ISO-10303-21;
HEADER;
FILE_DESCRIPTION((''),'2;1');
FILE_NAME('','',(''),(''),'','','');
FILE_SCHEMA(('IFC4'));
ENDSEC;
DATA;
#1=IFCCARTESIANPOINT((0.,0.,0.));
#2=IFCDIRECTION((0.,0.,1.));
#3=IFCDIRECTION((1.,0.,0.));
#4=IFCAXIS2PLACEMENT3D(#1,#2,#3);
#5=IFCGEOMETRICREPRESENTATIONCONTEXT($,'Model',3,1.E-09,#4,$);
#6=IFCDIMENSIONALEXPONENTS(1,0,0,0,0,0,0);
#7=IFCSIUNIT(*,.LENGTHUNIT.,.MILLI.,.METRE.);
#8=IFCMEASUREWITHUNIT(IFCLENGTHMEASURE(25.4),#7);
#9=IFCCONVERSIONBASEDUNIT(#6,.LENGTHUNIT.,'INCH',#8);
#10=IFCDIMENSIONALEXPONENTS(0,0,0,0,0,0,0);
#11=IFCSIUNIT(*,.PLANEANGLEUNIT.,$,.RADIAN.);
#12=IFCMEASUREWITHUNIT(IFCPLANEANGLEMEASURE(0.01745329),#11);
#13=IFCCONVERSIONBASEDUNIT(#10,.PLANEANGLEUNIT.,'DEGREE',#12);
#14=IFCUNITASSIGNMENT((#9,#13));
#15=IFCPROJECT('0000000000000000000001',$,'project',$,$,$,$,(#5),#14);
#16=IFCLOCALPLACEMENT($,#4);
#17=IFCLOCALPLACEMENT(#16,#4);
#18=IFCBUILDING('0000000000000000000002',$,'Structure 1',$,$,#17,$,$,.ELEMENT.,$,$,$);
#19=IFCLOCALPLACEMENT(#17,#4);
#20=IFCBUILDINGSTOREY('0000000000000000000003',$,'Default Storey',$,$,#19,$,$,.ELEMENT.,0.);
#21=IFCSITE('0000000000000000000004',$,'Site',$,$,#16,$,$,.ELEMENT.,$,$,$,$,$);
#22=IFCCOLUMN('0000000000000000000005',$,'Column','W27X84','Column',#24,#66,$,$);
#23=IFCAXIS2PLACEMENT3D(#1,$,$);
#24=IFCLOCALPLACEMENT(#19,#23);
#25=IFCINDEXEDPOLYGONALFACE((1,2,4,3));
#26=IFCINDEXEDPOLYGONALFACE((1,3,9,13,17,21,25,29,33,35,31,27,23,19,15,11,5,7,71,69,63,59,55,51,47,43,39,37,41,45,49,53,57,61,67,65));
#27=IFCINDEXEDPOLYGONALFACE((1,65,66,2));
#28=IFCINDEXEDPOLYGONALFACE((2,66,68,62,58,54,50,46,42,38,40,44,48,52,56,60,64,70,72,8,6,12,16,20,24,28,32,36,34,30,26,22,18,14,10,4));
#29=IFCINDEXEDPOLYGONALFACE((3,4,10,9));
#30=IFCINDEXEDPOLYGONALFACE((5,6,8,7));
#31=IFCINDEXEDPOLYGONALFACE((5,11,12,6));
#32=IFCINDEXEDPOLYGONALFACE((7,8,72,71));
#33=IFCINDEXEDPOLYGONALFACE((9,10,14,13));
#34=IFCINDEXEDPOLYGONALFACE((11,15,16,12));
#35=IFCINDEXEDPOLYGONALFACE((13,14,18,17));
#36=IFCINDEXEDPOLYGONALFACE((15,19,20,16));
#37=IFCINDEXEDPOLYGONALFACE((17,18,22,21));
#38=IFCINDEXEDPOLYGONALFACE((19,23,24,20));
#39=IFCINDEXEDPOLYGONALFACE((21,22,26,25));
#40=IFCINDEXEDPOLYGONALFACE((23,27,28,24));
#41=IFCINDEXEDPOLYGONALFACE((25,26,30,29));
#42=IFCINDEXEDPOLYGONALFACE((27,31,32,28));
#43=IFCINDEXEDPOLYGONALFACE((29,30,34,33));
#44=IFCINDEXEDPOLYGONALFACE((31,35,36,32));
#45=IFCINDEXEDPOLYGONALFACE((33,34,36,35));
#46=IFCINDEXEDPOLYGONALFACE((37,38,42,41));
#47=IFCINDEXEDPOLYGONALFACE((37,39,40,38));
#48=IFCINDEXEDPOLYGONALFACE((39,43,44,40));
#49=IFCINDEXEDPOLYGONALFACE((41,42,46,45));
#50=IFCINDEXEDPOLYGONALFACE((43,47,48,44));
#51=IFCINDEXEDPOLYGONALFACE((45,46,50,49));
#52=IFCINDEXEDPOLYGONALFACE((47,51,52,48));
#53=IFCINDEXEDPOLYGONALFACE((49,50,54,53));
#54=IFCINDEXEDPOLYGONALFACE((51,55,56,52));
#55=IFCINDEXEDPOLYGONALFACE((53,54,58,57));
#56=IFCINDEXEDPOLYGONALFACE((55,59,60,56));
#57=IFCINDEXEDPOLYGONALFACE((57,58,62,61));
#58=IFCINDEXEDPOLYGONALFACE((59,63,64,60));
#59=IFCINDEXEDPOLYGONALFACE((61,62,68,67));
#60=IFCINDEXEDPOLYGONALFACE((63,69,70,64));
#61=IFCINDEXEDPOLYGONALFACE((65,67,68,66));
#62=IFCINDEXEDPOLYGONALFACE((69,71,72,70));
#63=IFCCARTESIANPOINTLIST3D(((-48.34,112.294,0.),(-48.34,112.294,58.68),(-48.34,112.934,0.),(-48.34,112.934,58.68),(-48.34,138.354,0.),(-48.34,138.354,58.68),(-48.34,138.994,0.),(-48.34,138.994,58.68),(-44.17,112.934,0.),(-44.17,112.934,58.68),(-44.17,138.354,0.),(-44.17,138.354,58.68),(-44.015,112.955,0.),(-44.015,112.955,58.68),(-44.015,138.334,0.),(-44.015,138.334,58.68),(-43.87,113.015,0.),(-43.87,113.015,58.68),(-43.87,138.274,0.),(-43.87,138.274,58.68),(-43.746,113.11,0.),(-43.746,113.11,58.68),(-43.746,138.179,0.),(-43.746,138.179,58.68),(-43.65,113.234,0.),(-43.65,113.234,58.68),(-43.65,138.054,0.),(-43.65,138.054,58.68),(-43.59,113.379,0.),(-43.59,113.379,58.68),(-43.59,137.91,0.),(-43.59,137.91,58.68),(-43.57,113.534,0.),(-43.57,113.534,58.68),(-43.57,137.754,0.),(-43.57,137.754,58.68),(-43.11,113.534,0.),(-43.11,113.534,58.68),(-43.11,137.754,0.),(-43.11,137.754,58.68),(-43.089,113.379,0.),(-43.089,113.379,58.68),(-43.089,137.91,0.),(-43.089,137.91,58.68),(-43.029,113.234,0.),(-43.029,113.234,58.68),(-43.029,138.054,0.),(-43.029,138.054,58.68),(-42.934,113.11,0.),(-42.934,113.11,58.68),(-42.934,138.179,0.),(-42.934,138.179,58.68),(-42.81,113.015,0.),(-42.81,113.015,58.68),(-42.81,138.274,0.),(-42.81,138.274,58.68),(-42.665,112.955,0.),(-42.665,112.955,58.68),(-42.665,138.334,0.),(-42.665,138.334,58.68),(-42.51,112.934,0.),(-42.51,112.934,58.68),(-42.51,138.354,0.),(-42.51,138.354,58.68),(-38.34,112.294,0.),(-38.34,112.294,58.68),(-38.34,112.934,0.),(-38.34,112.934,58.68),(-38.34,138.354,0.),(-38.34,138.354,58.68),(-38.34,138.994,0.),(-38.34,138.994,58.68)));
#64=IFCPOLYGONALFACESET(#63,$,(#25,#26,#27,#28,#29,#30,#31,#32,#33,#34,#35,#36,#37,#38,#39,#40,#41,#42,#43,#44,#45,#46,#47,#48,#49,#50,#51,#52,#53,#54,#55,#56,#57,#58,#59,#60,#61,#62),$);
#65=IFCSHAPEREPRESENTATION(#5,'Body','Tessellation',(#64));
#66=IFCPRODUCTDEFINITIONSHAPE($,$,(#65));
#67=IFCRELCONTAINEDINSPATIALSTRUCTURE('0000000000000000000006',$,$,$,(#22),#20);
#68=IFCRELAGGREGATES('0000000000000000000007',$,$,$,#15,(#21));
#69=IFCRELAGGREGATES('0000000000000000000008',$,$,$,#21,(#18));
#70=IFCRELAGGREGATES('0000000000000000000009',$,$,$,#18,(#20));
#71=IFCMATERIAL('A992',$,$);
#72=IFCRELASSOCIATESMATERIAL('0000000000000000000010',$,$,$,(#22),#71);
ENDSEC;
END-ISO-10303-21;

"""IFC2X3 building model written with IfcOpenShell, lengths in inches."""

from ifc_helpers import new_model, entity, si_unit, converted_unit, frame, origin, origin_with_axes, origin_2d, place, context, project, spatial, i_section, extrude, clip, halfspace, material, element, save


model = new_model("IFC2X3")

# Units and contexts
model_context = context("Model", 3, precision=1e-09, world=origin_with_axes())
ifc_project = project(units=[converted_unit("LENGTHUNIT", "INCH", entity("IfcLengthMeasure", 25.4), si_unit("LENGTHUNIT", "METRE", prefix="MILLI"), dimensions=[1, 0, 0, 0, 0, 0, 0]), converted_unit("PLANEANGLEUNIT", "DEGREE", entity("IfcPlaneAngleMeasure", 0.01745329), si_unit("PLANEANGLEUNIT", "RADIAN"), dimensions=[0, 0, 0, 0, 0, 0, 0])], contexts=[model_context])

# Site, building, storey
site_placement = place(None, origin_with_axes())
site = spatial("IfcSite", under=ifc_project, at=site_placement, Name="Site", CompositionType="ELEMENT")
building_placement = place(site_placement, origin_with_axes())
building = spatial("IfcBuilding", under=site, at=building_placement, Name="Structure 1", CompositionType="ELEMENT")
storey_placement = place(building_placement, origin_with_axes())
storey = spatial("IfcBuildingStorey", under=building, at=storey_placement, Name="Default Storey", CompositionType="ELEMENT", Elevation=0.0)

# Column
ifc_material = material(Name="A992")
column_placement = place(None, frame((-43.34, 125.644, -28.356), z_axis=(0.0, 0.0, -1.0), x_axis=(-1.0, 0.0, 0.0)))
element("IfcColumn", 1, at=column_placement, inside=storey, material=ifc_material, Name="Column", Description="W27X84", ObjectType="Column", context=model_context, shape_type="Clipping", body=[
    clip(extrude(i_section(OverallWidth=10.0, OverallDepth=26.7, WebThickness=0.46, FlangeThickness=0.64, FilletRadius=0.6, at=origin_2d()), origin(), (0.0, 0.0, -1.0), 87.036), halfspace(frame((-43.34, -125.644, -28.356), z_axis=(0.0, 0.0, -1.0), x_axis=(-1.0, 0.0, 0.0)), True)),
])

save(model, "model.ifc")
